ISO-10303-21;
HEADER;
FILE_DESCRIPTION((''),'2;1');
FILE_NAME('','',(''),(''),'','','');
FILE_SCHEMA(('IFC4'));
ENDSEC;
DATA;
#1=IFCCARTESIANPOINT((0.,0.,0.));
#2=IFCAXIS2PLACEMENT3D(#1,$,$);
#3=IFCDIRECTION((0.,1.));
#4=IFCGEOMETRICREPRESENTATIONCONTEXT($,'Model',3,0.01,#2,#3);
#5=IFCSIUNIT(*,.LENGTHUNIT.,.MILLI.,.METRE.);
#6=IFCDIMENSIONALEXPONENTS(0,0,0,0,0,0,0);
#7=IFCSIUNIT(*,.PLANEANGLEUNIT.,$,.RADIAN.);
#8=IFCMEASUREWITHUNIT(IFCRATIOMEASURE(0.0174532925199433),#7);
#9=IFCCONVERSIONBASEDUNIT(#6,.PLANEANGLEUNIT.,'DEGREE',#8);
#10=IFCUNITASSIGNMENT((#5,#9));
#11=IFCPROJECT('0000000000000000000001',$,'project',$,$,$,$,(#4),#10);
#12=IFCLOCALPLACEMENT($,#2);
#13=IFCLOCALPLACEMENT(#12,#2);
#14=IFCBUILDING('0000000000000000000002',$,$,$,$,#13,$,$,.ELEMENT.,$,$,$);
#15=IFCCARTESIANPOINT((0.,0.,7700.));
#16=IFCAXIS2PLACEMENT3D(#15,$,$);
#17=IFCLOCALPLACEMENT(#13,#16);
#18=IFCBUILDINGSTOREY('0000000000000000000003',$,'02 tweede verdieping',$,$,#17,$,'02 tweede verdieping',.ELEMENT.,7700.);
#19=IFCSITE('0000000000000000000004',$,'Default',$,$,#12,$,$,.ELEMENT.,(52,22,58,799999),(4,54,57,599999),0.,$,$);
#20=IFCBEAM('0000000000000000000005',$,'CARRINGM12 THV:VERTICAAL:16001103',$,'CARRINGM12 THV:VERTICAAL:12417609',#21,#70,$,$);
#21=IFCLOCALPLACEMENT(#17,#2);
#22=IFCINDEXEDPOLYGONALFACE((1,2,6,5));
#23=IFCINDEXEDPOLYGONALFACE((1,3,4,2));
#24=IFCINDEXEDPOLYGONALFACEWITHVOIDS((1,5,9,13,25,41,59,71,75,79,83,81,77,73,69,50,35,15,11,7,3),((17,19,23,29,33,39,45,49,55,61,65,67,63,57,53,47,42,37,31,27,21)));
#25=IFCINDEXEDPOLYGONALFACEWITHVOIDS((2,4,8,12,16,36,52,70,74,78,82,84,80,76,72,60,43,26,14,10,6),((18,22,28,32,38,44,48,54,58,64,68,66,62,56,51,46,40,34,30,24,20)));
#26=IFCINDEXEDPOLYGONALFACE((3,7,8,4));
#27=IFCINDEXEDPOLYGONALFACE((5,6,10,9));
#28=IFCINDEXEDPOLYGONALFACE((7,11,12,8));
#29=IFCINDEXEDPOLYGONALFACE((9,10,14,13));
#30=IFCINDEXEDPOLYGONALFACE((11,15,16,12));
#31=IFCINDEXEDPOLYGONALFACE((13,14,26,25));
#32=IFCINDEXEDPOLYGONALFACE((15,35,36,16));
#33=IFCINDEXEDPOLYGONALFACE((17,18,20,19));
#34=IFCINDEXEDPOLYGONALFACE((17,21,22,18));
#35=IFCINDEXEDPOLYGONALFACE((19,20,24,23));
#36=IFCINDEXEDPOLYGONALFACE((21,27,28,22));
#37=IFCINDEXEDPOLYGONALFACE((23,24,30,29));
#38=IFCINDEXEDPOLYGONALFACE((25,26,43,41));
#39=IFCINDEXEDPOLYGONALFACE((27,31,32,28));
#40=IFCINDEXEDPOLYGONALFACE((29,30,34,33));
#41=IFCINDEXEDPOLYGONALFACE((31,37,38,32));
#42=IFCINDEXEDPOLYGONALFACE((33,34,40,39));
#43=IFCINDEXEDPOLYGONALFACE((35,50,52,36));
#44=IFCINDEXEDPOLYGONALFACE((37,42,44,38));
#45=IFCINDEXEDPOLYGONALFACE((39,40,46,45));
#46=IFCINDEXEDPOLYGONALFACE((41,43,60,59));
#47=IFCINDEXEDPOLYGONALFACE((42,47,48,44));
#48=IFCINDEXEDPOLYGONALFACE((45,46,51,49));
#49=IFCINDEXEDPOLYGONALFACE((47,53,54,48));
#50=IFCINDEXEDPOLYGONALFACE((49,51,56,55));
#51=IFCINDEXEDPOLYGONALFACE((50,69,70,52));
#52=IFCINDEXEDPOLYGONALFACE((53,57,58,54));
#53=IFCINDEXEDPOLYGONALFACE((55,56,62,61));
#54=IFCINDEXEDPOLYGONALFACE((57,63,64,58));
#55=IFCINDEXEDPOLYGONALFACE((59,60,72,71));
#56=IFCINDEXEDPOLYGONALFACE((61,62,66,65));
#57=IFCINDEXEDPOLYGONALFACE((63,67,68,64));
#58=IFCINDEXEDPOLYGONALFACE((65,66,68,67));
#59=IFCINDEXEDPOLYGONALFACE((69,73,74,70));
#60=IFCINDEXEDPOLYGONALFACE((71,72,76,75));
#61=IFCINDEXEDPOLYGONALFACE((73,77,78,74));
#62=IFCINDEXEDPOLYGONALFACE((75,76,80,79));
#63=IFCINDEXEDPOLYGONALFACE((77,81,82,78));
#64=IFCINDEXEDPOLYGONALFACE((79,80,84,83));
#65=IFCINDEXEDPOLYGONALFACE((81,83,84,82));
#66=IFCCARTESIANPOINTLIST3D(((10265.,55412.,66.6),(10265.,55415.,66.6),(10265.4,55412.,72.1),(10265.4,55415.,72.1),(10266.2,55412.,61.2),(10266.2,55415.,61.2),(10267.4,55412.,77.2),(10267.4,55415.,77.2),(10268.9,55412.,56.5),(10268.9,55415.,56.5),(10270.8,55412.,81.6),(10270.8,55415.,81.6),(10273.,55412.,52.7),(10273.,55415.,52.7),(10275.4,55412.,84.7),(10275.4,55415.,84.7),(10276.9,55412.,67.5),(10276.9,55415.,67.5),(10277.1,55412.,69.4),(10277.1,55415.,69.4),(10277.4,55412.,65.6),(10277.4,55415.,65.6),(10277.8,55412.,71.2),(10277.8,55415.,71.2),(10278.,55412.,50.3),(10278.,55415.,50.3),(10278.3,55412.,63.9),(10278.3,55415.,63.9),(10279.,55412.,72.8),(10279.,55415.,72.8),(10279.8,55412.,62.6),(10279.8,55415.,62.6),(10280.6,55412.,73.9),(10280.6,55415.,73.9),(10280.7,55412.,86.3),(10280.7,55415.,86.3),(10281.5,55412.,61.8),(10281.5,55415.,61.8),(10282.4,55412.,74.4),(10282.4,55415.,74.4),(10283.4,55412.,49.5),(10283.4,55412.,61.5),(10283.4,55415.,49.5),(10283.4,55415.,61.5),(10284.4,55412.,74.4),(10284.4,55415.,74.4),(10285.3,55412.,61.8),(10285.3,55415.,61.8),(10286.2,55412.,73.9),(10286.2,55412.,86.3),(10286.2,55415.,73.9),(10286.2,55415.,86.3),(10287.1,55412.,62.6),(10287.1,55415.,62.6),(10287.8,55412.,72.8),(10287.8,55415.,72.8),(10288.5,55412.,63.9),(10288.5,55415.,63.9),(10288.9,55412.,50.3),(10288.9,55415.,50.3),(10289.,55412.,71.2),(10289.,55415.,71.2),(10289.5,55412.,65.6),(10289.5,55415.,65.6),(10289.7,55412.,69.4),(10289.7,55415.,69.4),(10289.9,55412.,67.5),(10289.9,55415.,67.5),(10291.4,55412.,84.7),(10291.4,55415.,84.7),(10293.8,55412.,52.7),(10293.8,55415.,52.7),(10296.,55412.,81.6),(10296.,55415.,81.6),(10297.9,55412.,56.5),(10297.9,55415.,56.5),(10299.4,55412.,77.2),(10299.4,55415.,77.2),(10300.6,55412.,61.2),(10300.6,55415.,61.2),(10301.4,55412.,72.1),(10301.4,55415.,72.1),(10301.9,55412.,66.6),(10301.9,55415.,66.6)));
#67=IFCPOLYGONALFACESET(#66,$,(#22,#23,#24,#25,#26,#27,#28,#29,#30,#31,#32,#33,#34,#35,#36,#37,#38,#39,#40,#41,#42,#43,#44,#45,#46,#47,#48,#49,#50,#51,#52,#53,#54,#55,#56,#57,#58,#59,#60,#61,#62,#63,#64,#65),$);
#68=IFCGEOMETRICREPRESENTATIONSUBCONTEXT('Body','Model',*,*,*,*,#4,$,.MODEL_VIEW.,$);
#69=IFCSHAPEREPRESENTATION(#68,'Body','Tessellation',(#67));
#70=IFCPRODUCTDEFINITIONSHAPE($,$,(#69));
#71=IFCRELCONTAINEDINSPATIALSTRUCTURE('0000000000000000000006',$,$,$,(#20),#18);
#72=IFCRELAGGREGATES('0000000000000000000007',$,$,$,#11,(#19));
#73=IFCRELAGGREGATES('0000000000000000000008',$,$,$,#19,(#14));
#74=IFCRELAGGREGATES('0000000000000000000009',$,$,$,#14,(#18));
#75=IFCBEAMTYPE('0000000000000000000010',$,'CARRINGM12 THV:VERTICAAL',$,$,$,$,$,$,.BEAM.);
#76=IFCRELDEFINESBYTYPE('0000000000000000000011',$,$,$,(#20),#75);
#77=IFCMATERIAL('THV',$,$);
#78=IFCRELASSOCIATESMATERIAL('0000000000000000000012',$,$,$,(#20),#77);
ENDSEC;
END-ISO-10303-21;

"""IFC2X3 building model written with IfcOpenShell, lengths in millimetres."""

from ifc_helpers import new_model, entity, si_unit, converted_unit, direction, frame, origin, origin_2d_with_axis, place, context, subcontext, project, spatial, hollow_circle, extrude, material, type_object, element, save


model = new_model("IFC2X3")

# Units and contexts
model_context = context("Model", 3, precision=0.01, world=origin(), true_north=direction((0.0, 1.0)))
body_context = subcontext(model_context, "Body", "Model", "MODEL_VIEW")
ifc_project = project(units=[si_unit("LENGTHUNIT", "METRE", prefix="MILLI"), converted_unit("PLANEANGLEUNIT", "DEGREE", entity("IfcRatioMeasure", 0.0174532925199433), si_unit("PLANEANGLEUNIT", "RADIAN"), dimensions=[0, 0, 0, 0, 0, 0, 0])], contexts=[model_context])

# Site, building, storey
site_placement = place(None, origin())
site = spatial("IfcSite", under=ifc_project, at=site_placement, Name="Default", CompositionType="ELEMENT", RefLatitude=(52, 22, 58, 799999), RefLongitude=(4, 54, 57, 599999), RefElevation=0.0)
building_placement = place(site_placement, origin())
building = spatial("IfcBuilding", under=site, at=building_placement, CompositionType="ELEMENT")
storey_placement = place(building_placement, frame((0.0, 0.0, 7700.0)))
storey = spatial("IfcBuildingStorey", under=building, at=storey_placement, Name="02 tweede verdieping", LongName="02 tweede verdieping", CompositionType="ELEMENT", Elevation=7700.0)

# Beam
ifc_material_1 = material(Name="THV")
beam_type_1 = type_object("IfcBeamType", Name="CARRINGM12 THV:VERTICAAL", PredefinedType="BEAM")
beam_1_placement = place(storey_placement, origin())
element("IfcBeam", 1, at=beam_1_placement, inside=storey, type_object=beam_type_1, material=ifc_material_1, Name="CARRINGM12 THV:VERTICAAL:16001103", ObjectType="CARRINGM12 THV:VERTICAAL:12417609", context=body_context, shape_type="SweptSolid", body=[
    extrude(hollow_circle(Radius=18.5, WallThickness=12.0, at=origin_2d_with_axis()), frame((10283.4, 55412.0, 68.0), z_axis=(0.0, 1.0, 0.0), x_axis=(0.0, 0.0, -1.0)), (0.0, 0.0, 1.0), 3.0),
])

save(model, "model.ifc")
